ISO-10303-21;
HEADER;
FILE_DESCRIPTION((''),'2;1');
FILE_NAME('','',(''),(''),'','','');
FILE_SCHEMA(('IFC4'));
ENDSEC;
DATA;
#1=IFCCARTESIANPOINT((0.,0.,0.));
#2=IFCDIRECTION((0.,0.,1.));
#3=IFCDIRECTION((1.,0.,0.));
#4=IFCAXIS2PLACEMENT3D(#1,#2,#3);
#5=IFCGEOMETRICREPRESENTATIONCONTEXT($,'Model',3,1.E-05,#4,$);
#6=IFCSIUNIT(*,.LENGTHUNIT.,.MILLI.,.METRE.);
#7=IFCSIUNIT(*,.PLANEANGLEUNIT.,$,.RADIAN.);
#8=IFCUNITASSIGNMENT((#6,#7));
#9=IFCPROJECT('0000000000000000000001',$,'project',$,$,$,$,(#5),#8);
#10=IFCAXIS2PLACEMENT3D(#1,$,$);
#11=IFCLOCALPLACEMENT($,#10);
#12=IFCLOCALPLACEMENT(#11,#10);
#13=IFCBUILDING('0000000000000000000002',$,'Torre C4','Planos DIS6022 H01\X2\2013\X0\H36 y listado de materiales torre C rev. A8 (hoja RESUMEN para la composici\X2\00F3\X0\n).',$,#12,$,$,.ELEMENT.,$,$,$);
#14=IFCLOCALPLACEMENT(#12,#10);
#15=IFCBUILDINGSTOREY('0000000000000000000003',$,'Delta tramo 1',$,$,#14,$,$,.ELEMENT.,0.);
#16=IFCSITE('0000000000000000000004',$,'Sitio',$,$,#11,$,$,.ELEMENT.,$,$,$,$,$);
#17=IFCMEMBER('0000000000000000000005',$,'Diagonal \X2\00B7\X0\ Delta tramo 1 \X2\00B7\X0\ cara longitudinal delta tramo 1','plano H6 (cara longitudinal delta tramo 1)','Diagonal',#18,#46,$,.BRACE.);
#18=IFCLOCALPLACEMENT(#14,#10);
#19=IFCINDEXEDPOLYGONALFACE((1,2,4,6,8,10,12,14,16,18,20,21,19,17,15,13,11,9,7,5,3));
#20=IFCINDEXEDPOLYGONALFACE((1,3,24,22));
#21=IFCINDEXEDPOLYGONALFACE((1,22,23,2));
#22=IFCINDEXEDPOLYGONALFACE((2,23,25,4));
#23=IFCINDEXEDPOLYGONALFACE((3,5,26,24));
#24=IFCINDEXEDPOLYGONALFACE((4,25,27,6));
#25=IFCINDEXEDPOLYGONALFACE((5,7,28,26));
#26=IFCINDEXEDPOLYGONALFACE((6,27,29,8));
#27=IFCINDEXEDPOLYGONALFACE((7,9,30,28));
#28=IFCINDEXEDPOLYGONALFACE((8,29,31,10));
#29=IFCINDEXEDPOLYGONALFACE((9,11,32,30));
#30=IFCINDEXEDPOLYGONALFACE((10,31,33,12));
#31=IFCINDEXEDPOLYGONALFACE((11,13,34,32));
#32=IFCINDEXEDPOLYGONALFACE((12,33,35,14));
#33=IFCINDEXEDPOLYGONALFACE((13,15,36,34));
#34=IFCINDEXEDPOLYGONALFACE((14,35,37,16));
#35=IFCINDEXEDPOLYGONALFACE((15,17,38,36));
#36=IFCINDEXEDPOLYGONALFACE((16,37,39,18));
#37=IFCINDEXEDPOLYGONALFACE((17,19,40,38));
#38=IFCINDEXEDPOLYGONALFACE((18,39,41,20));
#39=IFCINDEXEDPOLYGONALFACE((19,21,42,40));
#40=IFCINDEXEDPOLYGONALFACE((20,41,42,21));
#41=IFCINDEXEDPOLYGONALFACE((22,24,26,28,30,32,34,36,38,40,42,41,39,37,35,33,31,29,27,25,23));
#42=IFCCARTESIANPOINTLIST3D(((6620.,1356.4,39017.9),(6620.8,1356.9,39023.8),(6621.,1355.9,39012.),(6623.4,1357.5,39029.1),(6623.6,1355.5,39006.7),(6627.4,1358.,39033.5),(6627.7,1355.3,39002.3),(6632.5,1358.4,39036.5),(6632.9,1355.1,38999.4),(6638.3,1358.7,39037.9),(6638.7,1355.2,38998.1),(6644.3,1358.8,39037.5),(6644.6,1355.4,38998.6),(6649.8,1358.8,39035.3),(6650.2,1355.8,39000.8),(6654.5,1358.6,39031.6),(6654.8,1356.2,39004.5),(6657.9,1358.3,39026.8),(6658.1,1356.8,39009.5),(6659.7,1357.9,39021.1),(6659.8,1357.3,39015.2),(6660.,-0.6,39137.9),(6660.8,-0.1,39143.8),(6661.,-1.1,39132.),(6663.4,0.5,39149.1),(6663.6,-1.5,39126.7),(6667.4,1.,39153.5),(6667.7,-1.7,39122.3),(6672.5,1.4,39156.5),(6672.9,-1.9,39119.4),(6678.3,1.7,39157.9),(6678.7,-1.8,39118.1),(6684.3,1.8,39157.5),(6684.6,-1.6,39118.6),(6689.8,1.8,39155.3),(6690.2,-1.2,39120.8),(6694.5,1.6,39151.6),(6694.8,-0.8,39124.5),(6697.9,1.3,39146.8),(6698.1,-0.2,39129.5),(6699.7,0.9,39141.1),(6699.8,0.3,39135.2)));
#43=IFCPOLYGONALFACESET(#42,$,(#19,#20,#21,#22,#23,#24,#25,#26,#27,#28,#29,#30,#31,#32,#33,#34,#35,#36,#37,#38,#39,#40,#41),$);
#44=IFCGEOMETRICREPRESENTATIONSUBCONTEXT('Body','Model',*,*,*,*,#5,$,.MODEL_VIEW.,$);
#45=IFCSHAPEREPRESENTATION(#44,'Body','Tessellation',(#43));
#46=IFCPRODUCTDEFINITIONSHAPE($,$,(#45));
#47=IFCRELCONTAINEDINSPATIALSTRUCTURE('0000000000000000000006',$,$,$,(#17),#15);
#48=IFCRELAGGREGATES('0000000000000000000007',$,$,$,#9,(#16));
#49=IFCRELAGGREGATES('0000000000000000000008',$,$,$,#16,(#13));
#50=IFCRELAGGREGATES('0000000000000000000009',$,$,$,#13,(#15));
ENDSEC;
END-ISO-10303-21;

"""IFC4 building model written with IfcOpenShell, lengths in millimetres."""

from ifc_helpers import new_model, si_unit, frame, origin, origin_with_axes, place, context, subcontext, project, spatial, circle, extrude, element, save


model = new_model("IFC4")

# Units and contexts
model_context = context("Model", 3, precision=1e-05, world=origin_with_axes())
body_context = subcontext(model_context, "Body", "Model", "MODEL_VIEW")
ifc_project = project(units=[si_unit("LENGTHUNIT", "METRE", prefix="MILLI"), si_unit("PLANEANGLEUNIT", "RADIAN")], contexts=[model_context])

# Site, building, storey
site_placement = place(None, origin())
site = spatial("IfcSite", under=ifc_project, at=site_placement, Name="Sitio", CompositionType="ELEMENT")
building_placement = place(site_placement, origin())
building = spatial("IfcBuilding", under=site, at=building_placement, Name="Torre C4", Description="Planos DIS6022 H01–H36 y listado de materiales torre C rev. A8 (hoja RESUMEN para la composición).", CompositionType="ELEMENT")
storey_placement = place(building_placement, origin())
storey = spatial("IfcBuildingStorey", under=building, at=storey_placement, Name="Delta tramo 1", CompositionType="ELEMENT", Elevation=0.0)

# Member
for number, where, z_axis, x_axis, name in (
    (1, (6680.0, 0.0, 39138.0), (-0.02935, 0.995684, -0.088049), (-0.999529, -0.030023, -0.006331), "Diagonal · Delta tramo 1 · cara longitudinal delta tramo 1"),
):
    element("IfcMember", number, at=place(storey_placement, frame(where, z_axis=z_axis, x_axis=x_axis)), inside=storey, Name=name, Description="plano H6 (cara longitudinal delta tramo 1)", ObjectType="Diagonal", PredefinedType="BRACE", context=body_context, shape_type="SweptSolid", body=[
        extrude(circle(Radius=20.0), None, (0.0, 0.0, 1.0), 1362.9),
    ])

save(model, "model.ifc")
